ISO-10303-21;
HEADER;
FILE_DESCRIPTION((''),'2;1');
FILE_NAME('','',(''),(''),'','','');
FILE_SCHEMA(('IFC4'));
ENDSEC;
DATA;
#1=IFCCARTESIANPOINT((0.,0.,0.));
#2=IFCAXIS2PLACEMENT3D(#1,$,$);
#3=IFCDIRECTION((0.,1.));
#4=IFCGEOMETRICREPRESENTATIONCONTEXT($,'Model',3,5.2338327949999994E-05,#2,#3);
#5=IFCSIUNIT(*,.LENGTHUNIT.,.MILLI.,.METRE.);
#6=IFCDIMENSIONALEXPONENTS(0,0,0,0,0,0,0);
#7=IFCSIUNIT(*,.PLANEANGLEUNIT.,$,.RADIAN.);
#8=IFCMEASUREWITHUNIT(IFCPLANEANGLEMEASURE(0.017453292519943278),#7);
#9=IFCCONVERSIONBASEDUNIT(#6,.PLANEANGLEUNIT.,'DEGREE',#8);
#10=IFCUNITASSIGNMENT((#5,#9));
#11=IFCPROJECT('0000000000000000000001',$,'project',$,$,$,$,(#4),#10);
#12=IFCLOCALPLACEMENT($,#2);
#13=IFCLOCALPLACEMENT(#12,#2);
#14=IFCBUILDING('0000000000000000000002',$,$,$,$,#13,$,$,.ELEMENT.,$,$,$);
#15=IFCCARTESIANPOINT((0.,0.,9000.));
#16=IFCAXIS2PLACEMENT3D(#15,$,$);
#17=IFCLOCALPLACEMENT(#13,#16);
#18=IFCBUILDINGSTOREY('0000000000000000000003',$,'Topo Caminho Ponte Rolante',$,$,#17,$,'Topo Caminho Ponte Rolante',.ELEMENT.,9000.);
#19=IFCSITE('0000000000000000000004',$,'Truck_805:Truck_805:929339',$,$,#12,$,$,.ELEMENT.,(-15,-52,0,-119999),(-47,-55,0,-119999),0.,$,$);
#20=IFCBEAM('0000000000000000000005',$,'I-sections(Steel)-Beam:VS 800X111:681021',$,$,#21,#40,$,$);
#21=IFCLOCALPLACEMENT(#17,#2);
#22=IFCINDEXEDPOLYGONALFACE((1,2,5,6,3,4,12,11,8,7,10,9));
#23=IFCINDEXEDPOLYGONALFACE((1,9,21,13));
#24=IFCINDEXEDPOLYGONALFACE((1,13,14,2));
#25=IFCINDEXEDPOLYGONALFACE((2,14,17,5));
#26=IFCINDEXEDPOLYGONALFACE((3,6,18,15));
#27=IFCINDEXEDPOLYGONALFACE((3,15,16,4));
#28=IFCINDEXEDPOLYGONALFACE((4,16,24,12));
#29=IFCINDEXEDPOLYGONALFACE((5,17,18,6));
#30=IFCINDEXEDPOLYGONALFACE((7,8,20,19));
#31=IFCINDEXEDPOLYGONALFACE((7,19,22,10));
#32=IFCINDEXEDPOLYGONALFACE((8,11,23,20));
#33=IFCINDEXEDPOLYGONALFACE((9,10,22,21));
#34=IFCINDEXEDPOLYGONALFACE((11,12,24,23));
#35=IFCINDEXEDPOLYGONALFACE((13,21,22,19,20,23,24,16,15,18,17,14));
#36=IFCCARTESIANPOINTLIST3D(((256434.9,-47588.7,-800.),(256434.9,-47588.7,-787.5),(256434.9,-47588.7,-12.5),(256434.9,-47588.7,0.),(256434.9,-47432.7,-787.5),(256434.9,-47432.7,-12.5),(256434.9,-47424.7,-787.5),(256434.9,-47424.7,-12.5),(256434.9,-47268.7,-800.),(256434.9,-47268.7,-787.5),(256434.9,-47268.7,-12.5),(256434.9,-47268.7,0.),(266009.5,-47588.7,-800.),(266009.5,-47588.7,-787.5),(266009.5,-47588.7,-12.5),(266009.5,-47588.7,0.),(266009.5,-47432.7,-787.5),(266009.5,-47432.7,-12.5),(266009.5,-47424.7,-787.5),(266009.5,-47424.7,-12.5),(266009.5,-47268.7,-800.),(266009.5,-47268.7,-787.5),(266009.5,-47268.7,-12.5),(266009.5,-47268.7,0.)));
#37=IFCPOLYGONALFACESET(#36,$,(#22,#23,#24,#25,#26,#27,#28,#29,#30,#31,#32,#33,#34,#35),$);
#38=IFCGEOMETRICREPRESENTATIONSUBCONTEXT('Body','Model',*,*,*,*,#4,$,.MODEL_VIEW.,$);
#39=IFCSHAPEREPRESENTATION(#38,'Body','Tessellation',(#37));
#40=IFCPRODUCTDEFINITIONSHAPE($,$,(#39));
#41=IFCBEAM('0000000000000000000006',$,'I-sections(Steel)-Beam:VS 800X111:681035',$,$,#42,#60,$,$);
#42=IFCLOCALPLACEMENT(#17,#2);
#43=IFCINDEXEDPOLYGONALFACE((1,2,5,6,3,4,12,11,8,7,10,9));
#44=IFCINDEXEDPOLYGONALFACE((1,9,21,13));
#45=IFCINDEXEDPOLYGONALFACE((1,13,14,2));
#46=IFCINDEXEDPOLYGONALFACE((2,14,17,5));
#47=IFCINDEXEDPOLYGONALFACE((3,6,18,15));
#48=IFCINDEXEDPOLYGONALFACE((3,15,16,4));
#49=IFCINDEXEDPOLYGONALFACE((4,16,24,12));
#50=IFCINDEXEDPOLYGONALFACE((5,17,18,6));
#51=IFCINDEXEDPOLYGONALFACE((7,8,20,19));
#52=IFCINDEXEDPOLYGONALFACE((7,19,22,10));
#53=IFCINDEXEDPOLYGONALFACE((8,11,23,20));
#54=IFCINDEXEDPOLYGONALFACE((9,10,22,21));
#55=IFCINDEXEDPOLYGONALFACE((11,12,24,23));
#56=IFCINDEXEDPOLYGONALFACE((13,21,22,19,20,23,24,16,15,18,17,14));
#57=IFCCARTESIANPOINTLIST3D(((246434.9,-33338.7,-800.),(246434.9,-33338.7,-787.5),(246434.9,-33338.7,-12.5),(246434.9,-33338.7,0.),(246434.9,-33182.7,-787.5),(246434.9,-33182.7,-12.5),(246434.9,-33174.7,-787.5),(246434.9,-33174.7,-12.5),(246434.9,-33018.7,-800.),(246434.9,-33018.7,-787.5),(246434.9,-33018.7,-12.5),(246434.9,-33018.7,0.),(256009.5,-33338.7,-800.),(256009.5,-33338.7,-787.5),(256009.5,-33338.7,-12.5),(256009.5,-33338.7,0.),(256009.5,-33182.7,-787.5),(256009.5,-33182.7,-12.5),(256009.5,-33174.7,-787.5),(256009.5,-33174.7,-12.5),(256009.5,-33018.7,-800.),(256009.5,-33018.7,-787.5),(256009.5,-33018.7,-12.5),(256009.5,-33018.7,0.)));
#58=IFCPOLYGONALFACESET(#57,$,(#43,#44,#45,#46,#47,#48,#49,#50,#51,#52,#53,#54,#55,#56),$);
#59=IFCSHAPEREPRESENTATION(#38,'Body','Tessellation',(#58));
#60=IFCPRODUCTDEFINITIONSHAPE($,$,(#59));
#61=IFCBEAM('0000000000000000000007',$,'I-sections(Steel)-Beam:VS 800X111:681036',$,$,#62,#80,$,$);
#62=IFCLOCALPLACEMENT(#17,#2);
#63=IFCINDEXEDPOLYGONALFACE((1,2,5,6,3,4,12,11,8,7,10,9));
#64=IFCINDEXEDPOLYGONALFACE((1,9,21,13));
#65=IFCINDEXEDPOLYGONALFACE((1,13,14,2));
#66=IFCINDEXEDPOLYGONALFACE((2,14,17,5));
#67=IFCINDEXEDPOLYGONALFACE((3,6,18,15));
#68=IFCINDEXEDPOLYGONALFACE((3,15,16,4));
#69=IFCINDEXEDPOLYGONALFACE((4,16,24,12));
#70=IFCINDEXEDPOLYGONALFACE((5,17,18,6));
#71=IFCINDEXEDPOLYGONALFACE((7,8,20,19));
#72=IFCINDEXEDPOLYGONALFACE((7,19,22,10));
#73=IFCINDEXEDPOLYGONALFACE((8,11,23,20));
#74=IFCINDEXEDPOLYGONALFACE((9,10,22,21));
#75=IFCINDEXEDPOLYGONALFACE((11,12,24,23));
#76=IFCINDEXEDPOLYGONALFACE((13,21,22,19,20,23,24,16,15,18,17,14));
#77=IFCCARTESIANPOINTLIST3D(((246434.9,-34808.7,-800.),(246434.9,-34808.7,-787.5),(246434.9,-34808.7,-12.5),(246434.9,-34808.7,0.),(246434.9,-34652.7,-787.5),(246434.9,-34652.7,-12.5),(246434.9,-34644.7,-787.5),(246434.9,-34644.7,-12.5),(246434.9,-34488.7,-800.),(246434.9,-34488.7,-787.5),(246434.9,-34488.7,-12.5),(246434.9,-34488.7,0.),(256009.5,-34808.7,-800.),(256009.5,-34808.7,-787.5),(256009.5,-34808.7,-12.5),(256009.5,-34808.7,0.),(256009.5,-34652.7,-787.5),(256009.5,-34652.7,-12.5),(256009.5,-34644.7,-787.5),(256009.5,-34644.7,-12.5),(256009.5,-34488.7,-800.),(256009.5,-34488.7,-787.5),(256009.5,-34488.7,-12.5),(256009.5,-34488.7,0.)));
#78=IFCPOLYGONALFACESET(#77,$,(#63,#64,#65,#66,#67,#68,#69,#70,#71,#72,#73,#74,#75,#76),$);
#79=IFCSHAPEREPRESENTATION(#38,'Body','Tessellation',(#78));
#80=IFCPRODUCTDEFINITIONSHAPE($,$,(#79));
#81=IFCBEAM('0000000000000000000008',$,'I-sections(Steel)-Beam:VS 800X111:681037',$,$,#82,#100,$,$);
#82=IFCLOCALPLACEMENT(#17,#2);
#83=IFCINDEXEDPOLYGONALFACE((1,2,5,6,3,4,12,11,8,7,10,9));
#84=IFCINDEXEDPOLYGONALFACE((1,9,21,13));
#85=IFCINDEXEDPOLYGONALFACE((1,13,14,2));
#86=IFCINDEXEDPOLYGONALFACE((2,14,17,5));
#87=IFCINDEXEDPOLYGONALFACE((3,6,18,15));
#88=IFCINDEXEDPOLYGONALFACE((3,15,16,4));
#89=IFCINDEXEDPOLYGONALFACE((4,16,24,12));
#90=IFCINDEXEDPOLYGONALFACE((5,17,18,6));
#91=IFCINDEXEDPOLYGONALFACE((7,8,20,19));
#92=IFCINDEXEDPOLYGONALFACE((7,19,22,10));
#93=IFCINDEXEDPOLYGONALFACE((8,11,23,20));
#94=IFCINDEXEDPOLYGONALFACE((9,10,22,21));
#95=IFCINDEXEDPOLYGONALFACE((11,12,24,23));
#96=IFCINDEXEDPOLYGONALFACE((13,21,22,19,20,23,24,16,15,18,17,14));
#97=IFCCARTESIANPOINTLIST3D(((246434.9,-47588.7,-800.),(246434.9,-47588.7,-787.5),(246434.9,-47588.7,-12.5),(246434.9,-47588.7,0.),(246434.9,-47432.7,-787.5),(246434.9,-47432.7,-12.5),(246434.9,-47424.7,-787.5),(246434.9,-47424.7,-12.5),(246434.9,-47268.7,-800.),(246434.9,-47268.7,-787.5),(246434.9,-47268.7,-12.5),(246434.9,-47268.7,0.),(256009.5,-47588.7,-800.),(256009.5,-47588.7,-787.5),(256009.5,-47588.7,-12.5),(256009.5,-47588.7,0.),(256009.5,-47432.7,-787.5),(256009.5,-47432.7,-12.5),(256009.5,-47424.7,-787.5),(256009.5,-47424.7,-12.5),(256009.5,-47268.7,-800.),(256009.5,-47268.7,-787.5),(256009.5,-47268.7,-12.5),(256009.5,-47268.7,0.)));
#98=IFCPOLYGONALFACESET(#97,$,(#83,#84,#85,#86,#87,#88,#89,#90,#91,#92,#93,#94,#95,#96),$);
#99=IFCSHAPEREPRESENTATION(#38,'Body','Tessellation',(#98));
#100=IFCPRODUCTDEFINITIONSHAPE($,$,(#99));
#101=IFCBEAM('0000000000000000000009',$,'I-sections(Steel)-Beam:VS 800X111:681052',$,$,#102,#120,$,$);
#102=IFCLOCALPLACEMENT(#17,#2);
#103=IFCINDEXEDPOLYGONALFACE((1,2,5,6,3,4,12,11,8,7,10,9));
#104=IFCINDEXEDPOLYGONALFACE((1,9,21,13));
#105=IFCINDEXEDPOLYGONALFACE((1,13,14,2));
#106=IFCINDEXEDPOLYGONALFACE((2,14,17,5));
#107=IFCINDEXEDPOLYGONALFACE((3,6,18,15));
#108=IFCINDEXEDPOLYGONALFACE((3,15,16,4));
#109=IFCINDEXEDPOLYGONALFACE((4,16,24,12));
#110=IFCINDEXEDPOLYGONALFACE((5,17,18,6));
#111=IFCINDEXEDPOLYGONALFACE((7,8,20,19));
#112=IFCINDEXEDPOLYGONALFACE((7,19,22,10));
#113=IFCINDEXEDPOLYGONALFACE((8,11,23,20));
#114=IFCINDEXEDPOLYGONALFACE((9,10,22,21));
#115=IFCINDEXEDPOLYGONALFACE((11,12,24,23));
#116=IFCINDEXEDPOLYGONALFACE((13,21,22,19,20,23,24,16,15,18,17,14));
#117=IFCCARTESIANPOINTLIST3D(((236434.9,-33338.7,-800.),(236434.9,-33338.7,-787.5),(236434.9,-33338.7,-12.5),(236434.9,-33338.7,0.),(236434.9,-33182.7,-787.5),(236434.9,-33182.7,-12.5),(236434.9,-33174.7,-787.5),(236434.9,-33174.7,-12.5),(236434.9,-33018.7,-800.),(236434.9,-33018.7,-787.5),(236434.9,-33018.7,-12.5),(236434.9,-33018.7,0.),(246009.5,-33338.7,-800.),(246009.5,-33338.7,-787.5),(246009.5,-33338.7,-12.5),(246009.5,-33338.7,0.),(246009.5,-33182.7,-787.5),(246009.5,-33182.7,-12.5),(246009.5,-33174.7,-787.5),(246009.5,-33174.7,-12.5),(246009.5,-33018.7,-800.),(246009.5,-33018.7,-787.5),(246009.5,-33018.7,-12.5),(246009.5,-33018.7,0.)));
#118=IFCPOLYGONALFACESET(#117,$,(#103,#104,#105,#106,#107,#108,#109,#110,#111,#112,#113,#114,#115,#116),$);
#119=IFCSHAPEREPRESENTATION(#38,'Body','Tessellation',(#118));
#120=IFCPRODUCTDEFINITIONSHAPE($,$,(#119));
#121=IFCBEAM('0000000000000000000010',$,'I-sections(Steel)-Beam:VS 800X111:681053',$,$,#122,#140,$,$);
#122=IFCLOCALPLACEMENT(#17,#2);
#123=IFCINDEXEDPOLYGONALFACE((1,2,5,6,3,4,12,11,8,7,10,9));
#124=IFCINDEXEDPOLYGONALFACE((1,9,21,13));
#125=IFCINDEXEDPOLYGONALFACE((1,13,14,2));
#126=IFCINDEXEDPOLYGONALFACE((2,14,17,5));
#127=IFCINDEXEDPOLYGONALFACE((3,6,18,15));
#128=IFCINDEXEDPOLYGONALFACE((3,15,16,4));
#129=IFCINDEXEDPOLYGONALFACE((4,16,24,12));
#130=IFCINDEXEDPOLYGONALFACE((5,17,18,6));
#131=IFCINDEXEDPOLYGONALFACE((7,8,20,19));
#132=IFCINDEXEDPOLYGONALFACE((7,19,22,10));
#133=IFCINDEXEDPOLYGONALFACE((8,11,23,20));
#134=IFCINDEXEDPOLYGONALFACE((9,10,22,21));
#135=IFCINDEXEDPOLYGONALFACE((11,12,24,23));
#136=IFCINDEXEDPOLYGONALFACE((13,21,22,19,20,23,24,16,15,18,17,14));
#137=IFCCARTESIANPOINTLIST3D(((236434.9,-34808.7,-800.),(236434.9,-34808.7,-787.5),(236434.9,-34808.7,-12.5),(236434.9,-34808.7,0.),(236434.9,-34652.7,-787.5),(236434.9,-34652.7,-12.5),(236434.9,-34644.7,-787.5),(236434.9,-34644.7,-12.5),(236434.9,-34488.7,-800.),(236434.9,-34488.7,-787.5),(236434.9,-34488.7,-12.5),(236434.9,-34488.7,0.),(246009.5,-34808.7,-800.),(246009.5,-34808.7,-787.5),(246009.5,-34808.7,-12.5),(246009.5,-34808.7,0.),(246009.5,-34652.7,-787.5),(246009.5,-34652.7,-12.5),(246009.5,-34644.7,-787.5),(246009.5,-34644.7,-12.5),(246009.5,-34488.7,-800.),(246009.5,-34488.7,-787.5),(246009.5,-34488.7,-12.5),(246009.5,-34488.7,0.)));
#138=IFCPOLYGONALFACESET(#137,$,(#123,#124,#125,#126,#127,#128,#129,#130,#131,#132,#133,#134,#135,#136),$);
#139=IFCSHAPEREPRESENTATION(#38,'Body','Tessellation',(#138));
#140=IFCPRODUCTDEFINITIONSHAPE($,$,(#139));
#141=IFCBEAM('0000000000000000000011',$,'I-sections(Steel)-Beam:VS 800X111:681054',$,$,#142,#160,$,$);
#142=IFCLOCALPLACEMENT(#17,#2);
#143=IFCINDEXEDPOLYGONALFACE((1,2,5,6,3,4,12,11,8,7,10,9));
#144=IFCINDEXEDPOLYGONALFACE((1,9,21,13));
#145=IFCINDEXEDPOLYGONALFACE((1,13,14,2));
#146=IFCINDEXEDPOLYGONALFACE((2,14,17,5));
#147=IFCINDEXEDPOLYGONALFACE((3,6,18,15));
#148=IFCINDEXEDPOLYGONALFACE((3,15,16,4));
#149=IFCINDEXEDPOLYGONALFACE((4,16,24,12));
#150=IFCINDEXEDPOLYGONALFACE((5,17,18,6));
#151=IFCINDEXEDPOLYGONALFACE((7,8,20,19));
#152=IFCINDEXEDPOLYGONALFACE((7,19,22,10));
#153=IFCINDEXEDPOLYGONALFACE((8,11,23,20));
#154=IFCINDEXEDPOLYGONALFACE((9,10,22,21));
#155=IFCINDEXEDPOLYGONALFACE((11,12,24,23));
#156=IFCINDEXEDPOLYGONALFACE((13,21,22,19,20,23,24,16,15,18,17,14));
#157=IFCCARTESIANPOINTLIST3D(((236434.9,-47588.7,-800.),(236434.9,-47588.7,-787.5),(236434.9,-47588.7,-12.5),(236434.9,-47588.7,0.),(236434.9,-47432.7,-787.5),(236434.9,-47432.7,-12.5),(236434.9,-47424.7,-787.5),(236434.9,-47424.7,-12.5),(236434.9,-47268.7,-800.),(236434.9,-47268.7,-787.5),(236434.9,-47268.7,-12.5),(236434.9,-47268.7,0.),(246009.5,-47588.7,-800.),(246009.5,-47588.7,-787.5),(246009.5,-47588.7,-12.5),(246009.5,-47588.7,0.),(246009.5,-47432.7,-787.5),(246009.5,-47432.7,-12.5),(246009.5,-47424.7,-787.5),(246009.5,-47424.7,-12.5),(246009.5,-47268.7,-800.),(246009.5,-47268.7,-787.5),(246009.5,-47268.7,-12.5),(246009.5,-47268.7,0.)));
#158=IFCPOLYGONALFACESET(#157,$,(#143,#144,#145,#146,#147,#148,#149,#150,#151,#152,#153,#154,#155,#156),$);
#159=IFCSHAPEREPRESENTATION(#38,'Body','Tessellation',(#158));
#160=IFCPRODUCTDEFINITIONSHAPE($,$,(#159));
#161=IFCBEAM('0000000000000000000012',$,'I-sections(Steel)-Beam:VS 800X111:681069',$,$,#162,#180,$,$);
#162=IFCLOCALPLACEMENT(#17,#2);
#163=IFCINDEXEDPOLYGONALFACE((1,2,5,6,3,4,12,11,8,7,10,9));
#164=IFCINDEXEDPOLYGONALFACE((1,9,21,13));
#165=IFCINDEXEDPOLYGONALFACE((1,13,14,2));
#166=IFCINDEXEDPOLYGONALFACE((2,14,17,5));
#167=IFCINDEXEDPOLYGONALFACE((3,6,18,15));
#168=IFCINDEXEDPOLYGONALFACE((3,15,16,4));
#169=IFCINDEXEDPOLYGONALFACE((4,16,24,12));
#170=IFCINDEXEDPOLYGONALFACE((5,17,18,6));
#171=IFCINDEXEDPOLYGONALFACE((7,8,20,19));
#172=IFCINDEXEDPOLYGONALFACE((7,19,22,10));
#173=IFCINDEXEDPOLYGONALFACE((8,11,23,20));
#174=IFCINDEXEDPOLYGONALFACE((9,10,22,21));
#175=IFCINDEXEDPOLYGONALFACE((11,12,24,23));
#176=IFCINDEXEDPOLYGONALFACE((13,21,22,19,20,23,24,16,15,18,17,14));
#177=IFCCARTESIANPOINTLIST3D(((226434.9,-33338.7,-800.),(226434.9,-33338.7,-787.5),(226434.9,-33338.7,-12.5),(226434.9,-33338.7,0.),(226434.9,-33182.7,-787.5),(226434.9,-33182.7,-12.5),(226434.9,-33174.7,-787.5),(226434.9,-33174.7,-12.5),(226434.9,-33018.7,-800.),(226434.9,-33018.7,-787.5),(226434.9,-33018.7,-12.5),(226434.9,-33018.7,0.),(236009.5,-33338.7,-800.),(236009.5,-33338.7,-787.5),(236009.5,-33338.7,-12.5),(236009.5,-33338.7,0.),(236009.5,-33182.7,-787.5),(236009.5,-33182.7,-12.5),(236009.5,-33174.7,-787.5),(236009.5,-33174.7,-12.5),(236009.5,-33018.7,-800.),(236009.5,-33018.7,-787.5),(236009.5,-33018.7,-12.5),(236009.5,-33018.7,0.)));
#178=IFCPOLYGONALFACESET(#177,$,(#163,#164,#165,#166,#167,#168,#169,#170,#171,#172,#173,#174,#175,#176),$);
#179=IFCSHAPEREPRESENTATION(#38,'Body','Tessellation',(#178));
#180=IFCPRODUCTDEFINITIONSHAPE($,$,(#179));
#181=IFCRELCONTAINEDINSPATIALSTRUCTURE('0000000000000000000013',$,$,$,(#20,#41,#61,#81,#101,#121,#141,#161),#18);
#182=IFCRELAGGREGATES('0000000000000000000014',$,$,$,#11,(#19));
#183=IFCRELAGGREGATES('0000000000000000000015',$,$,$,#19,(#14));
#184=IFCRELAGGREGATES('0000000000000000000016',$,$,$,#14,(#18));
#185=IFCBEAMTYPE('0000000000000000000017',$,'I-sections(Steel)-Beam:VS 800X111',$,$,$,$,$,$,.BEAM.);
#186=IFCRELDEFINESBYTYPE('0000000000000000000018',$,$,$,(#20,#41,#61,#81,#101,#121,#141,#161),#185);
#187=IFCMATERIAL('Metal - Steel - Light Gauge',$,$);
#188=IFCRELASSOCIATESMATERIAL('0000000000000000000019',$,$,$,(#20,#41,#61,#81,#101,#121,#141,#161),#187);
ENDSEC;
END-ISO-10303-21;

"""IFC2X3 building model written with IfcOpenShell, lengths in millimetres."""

from ifc_helpers import new_model, entity, si_unit, converted_unit, direction, frame, frame_2d, origin, place, context, subcontext, project, spatial, polyline, i_section, outline, extrude, material, type_object, element, save


model = new_model("IFC2X3")

# Units and contexts
model_context = context("Model", 3, precision=5.2338327949999994e-05, world=origin(), true_north=direction((0.0, 1.0)))
body_context = subcontext(model_context, "Body", "Model", "MODEL_VIEW")
ifc_project = project(units=[si_unit("LENGTHUNIT", "METRE", prefix="MILLI"), converted_unit("PLANEANGLEUNIT", "DEGREE", entity("IfcPlaneAngleMeasure", 0.017453292519943278), si_unit("PLANEANGLEUNIT", "RADIAN"), dimensions=[0, 0, 0, 0, 0, 0, 0])], contexts=[model_context])

# Site, building, storey
site_placement = place(None, origin())
site = spatial("IfcSite", under=ifc_project, at=site_placement, Name="Truck_805:Truck_805:929339", CompositionType="ELEMENT", RefLatitude=(-15, -52, 0, -119999), RefLongitude=(-47, -55, 0, -119999), RefElevation=0.0)
building_placement = place(site_placement, origin())
building = spatial("IfcBuilding", under=site, at=building_placement, CompositionType="ELEMENT")
storey_placement = place(building_placement, frame((0.0, 0.0, 9000.0)))
storey = spatial("IfcBuildingStorey", under=building, at=storey_placement, Name="Topo Caminho Ponte Rolante", LongName="Topo Caminho Ponte Rolante", CompositionType="ELEMENT", Elevation=9000.0)

# Beams
ifc_material = material(Name="Metal - Steel - Light Gauge")
beam_type_1 = type_object("IfcBeamType", Name="I-sections(Steel)-Beam:VS 800X111", PredefinedType="BEAM")
beam_1_placement = place(storey_placement, frame((256222.2, -47428.7, 0.0)))
element("IfcBeam", 1, at=beam_1_placement, inside=storey, type_object=beam_type_1, material=ifc_material, Name="I-sections(Steel)-Beam:VS 800X111:681021", context=body_context, shape_type="SweptSolid", body=[
    extrude(i_section(OverallWidth=320.0, OverallDepth=800.0, WebThickness=8.0, FlangeThickness=12.5, at=frame_2d((0.0, 0.0), x_axis=(0.0, 1.0))), frame((212.7, 0.0, -400.0), z_axis=(1.0, 0.0, 0.0), x_axis=(0.0, 0.0, -1.0)), (0.0, 0.0, 1.0), 9574.6),
])
beam_2_placement = place(storey_placement, frame((246222.2, -33178.7, 0.0)))
element("IfcBeam", 2, at=beam_2_placement, inside=storey, type_object=beam_type_1, material=ifc_material, Name="I-sections(Steel)-Beam:VS 800X111:681035", context=body_context, shape_type="SweptSolid", body=[
    extrude(i_section(OverallWidth=320.0, OverallDepth=800.0, WebThickness=8.0, FlangeThickness=12.5, at=frame_2d((0.0, 0.0), x_axis=(0.0, 1.0))), frame((212.7, 0.0, -400.0), z_axis=(1.0, 0.0, 0.0), x_axis=(0.0, 0.0, -1.0)), (0.0, 0.0, 1.0), 9574.6),
])
beam_3_placement = place(storey_placement, frame((246222.2, -34648.7, 0.0)))
element("IfcBeam", 3, at=beam_3_placement, inside=storey, type_object=beam_type_1, material=ifc_material, Name="I-sections(Steel)-Beam:VS 800X111:681036", context=body_context, shape_type="SweptSolid", body=[
    extrude(outline(polyline([(387.5, -160.0), (400.0, -160.0), (400.0, 160.0), (387.5, 160.0), (387.5, 4.0), (-387.5, 4.0), (-387.5, 160.0), (-400.0, 160.0), (-400.0, -160.0), (-387.5, -160.0), (-387.5, -4.0), (387.5, -4.0), (387.5, -160.0)])), frame((212.7, 0.0, -400.0), z_axis=(1.0, 0.0, 0.0), x_axis=(0.0, 0.0, -1.0)), (0.0, 0.0, 1.0), 9574.6),
])
beam_4_placement = place(storey_placement, frame((246222.2, -47428.7, 0.0)))
element("IfcBeam", 4, at=beam_4_placement, inside=storey, type_object=beam_type_1, material=ifc_material, Name="I-sections(Steel)-Beam:VS 800X111:681037", context=body_context, shape_type="SweptSolid", body=[
    extrude(i_section(OverallWidth=320.0, OverallDepth=800.0, WebThickness=8.0, FlangeThickness=12.5, at=frame_2d((0.0, 0.0), x_axis=(0.0, 1.0))), frame((212.7, 0.0, -400.0), z_axis=(1.0, 0.0, 0.0), x_axis=(0.0, 0.0, -1.0)), (0.0, 0.0, 1.0), 9574.6),
])
beam_5_placement = place(storey_placement, frame((236222.2, -33178.7, 0.0)))
element("IfcBeam", 5, at=beam_5_placement, inside=storey, type_object=beam_type_1, material=ifc_material, Name="I-sections(Steel)-Beam:VS 800X111:681052", context=body_context, shape_type="SweptSolid", body=[
    extrude(i_section(OverallWidth=320.0, OverallDepth=800.0, WebThickness=8.0, FlangeThickness=12.5, at=frame_2d((0.0, 0.0), x_axis=(0.0, 1.0))), frame((212.7, 0.0, -400.0), z_axis=(1.0, 0.0, 0.0), x_axis=(0.0, 0.0, -1.0)), (0.0, 0.0, 1.0), 9574.6),
])
beam_6_placement = place(storey_placement, frame((236222.2, -34648.7, 0.0)))
element("IfcBeam", 6, at=beam_6_placement, inside=storey, type_object=beam_type_1, material=ifc_material, Name="I-sections(Steel)-Beam:VS 800X111:681053", context=body_context, shape_type="SweptSolid", body=[
    extrude(outline(polyline([(387.5, -160.0), (400.0, -160.0), (400.0, 160.0), (387.5, 160.0), (387.5, 4.0), (-387.5, 4.0), (-387.5, 160.0), (-400.0, 160.0), (-400.0, -160.0), (-387.5, -160.0), (-387.5, -4.0), (387.5, -4.0), (387.5, -160.0)])), frame((212.7, 0.0, -400.0), z_axis=(1.0, 0.0, 0.0), x_axis=(0.0, 0.0, -1.0)), (0.0, 0.0, 1.0), 9574.6),
])
beam_7_placement = place(storey_placement, frame((236222.2, -47428.7, 0.0)))
element("IfcBeam", 7, at=beam_7_placement, inside=storey, type_object=beam_type_1, material=ifc_material, Name="I-sections(Steel)-Beam:VS 800X111:681054", context=body_context, shape_type="SweptSolid", body=[
    extrude(i_section(OverallWidth=320.0, OverallDepth=800.0, WebThickness=8.0, FlangeThickness=12.5, at=frame_2d((0.0, 0.0), x_axis=(0.0, 1.0))), frame((212.7, 0.0, -400.0), z_axis=(1.0, 0.0, 0.0), x_axis=(0.0, 0.0, -1.0)), (0.0, 0.0, 1.0), 9574.6),
])
beam_8_placement = place(storey_placement, frame((226222.2, -33178.7, 0.0)))
element("IfcBeam", 8, at=beam_8_placement, inside=storey, type_object=beam_type_1, material=ifc_material, Name="I-sections(Steel)-Beam:VS 800X111:681069", context=body_context, shape_type="SweptSolid", body=[
    extrude(i_section(OverallWidth=320.0, OverallDepth=800.0, WebThickness=8.0, FlangeThickness=12.5, at=frame_2d((0.0, 0.0), x_axis=(0.0, 1.0))), frame((212.7, 0.0, -400.0), z_axis=(1.0, 0.0, 0.0), x_axis=(0.0, 0.0, -1.0)), (0.0, 0.0, 1.0), 9574.6),
])

save(model, "model.ifc")
